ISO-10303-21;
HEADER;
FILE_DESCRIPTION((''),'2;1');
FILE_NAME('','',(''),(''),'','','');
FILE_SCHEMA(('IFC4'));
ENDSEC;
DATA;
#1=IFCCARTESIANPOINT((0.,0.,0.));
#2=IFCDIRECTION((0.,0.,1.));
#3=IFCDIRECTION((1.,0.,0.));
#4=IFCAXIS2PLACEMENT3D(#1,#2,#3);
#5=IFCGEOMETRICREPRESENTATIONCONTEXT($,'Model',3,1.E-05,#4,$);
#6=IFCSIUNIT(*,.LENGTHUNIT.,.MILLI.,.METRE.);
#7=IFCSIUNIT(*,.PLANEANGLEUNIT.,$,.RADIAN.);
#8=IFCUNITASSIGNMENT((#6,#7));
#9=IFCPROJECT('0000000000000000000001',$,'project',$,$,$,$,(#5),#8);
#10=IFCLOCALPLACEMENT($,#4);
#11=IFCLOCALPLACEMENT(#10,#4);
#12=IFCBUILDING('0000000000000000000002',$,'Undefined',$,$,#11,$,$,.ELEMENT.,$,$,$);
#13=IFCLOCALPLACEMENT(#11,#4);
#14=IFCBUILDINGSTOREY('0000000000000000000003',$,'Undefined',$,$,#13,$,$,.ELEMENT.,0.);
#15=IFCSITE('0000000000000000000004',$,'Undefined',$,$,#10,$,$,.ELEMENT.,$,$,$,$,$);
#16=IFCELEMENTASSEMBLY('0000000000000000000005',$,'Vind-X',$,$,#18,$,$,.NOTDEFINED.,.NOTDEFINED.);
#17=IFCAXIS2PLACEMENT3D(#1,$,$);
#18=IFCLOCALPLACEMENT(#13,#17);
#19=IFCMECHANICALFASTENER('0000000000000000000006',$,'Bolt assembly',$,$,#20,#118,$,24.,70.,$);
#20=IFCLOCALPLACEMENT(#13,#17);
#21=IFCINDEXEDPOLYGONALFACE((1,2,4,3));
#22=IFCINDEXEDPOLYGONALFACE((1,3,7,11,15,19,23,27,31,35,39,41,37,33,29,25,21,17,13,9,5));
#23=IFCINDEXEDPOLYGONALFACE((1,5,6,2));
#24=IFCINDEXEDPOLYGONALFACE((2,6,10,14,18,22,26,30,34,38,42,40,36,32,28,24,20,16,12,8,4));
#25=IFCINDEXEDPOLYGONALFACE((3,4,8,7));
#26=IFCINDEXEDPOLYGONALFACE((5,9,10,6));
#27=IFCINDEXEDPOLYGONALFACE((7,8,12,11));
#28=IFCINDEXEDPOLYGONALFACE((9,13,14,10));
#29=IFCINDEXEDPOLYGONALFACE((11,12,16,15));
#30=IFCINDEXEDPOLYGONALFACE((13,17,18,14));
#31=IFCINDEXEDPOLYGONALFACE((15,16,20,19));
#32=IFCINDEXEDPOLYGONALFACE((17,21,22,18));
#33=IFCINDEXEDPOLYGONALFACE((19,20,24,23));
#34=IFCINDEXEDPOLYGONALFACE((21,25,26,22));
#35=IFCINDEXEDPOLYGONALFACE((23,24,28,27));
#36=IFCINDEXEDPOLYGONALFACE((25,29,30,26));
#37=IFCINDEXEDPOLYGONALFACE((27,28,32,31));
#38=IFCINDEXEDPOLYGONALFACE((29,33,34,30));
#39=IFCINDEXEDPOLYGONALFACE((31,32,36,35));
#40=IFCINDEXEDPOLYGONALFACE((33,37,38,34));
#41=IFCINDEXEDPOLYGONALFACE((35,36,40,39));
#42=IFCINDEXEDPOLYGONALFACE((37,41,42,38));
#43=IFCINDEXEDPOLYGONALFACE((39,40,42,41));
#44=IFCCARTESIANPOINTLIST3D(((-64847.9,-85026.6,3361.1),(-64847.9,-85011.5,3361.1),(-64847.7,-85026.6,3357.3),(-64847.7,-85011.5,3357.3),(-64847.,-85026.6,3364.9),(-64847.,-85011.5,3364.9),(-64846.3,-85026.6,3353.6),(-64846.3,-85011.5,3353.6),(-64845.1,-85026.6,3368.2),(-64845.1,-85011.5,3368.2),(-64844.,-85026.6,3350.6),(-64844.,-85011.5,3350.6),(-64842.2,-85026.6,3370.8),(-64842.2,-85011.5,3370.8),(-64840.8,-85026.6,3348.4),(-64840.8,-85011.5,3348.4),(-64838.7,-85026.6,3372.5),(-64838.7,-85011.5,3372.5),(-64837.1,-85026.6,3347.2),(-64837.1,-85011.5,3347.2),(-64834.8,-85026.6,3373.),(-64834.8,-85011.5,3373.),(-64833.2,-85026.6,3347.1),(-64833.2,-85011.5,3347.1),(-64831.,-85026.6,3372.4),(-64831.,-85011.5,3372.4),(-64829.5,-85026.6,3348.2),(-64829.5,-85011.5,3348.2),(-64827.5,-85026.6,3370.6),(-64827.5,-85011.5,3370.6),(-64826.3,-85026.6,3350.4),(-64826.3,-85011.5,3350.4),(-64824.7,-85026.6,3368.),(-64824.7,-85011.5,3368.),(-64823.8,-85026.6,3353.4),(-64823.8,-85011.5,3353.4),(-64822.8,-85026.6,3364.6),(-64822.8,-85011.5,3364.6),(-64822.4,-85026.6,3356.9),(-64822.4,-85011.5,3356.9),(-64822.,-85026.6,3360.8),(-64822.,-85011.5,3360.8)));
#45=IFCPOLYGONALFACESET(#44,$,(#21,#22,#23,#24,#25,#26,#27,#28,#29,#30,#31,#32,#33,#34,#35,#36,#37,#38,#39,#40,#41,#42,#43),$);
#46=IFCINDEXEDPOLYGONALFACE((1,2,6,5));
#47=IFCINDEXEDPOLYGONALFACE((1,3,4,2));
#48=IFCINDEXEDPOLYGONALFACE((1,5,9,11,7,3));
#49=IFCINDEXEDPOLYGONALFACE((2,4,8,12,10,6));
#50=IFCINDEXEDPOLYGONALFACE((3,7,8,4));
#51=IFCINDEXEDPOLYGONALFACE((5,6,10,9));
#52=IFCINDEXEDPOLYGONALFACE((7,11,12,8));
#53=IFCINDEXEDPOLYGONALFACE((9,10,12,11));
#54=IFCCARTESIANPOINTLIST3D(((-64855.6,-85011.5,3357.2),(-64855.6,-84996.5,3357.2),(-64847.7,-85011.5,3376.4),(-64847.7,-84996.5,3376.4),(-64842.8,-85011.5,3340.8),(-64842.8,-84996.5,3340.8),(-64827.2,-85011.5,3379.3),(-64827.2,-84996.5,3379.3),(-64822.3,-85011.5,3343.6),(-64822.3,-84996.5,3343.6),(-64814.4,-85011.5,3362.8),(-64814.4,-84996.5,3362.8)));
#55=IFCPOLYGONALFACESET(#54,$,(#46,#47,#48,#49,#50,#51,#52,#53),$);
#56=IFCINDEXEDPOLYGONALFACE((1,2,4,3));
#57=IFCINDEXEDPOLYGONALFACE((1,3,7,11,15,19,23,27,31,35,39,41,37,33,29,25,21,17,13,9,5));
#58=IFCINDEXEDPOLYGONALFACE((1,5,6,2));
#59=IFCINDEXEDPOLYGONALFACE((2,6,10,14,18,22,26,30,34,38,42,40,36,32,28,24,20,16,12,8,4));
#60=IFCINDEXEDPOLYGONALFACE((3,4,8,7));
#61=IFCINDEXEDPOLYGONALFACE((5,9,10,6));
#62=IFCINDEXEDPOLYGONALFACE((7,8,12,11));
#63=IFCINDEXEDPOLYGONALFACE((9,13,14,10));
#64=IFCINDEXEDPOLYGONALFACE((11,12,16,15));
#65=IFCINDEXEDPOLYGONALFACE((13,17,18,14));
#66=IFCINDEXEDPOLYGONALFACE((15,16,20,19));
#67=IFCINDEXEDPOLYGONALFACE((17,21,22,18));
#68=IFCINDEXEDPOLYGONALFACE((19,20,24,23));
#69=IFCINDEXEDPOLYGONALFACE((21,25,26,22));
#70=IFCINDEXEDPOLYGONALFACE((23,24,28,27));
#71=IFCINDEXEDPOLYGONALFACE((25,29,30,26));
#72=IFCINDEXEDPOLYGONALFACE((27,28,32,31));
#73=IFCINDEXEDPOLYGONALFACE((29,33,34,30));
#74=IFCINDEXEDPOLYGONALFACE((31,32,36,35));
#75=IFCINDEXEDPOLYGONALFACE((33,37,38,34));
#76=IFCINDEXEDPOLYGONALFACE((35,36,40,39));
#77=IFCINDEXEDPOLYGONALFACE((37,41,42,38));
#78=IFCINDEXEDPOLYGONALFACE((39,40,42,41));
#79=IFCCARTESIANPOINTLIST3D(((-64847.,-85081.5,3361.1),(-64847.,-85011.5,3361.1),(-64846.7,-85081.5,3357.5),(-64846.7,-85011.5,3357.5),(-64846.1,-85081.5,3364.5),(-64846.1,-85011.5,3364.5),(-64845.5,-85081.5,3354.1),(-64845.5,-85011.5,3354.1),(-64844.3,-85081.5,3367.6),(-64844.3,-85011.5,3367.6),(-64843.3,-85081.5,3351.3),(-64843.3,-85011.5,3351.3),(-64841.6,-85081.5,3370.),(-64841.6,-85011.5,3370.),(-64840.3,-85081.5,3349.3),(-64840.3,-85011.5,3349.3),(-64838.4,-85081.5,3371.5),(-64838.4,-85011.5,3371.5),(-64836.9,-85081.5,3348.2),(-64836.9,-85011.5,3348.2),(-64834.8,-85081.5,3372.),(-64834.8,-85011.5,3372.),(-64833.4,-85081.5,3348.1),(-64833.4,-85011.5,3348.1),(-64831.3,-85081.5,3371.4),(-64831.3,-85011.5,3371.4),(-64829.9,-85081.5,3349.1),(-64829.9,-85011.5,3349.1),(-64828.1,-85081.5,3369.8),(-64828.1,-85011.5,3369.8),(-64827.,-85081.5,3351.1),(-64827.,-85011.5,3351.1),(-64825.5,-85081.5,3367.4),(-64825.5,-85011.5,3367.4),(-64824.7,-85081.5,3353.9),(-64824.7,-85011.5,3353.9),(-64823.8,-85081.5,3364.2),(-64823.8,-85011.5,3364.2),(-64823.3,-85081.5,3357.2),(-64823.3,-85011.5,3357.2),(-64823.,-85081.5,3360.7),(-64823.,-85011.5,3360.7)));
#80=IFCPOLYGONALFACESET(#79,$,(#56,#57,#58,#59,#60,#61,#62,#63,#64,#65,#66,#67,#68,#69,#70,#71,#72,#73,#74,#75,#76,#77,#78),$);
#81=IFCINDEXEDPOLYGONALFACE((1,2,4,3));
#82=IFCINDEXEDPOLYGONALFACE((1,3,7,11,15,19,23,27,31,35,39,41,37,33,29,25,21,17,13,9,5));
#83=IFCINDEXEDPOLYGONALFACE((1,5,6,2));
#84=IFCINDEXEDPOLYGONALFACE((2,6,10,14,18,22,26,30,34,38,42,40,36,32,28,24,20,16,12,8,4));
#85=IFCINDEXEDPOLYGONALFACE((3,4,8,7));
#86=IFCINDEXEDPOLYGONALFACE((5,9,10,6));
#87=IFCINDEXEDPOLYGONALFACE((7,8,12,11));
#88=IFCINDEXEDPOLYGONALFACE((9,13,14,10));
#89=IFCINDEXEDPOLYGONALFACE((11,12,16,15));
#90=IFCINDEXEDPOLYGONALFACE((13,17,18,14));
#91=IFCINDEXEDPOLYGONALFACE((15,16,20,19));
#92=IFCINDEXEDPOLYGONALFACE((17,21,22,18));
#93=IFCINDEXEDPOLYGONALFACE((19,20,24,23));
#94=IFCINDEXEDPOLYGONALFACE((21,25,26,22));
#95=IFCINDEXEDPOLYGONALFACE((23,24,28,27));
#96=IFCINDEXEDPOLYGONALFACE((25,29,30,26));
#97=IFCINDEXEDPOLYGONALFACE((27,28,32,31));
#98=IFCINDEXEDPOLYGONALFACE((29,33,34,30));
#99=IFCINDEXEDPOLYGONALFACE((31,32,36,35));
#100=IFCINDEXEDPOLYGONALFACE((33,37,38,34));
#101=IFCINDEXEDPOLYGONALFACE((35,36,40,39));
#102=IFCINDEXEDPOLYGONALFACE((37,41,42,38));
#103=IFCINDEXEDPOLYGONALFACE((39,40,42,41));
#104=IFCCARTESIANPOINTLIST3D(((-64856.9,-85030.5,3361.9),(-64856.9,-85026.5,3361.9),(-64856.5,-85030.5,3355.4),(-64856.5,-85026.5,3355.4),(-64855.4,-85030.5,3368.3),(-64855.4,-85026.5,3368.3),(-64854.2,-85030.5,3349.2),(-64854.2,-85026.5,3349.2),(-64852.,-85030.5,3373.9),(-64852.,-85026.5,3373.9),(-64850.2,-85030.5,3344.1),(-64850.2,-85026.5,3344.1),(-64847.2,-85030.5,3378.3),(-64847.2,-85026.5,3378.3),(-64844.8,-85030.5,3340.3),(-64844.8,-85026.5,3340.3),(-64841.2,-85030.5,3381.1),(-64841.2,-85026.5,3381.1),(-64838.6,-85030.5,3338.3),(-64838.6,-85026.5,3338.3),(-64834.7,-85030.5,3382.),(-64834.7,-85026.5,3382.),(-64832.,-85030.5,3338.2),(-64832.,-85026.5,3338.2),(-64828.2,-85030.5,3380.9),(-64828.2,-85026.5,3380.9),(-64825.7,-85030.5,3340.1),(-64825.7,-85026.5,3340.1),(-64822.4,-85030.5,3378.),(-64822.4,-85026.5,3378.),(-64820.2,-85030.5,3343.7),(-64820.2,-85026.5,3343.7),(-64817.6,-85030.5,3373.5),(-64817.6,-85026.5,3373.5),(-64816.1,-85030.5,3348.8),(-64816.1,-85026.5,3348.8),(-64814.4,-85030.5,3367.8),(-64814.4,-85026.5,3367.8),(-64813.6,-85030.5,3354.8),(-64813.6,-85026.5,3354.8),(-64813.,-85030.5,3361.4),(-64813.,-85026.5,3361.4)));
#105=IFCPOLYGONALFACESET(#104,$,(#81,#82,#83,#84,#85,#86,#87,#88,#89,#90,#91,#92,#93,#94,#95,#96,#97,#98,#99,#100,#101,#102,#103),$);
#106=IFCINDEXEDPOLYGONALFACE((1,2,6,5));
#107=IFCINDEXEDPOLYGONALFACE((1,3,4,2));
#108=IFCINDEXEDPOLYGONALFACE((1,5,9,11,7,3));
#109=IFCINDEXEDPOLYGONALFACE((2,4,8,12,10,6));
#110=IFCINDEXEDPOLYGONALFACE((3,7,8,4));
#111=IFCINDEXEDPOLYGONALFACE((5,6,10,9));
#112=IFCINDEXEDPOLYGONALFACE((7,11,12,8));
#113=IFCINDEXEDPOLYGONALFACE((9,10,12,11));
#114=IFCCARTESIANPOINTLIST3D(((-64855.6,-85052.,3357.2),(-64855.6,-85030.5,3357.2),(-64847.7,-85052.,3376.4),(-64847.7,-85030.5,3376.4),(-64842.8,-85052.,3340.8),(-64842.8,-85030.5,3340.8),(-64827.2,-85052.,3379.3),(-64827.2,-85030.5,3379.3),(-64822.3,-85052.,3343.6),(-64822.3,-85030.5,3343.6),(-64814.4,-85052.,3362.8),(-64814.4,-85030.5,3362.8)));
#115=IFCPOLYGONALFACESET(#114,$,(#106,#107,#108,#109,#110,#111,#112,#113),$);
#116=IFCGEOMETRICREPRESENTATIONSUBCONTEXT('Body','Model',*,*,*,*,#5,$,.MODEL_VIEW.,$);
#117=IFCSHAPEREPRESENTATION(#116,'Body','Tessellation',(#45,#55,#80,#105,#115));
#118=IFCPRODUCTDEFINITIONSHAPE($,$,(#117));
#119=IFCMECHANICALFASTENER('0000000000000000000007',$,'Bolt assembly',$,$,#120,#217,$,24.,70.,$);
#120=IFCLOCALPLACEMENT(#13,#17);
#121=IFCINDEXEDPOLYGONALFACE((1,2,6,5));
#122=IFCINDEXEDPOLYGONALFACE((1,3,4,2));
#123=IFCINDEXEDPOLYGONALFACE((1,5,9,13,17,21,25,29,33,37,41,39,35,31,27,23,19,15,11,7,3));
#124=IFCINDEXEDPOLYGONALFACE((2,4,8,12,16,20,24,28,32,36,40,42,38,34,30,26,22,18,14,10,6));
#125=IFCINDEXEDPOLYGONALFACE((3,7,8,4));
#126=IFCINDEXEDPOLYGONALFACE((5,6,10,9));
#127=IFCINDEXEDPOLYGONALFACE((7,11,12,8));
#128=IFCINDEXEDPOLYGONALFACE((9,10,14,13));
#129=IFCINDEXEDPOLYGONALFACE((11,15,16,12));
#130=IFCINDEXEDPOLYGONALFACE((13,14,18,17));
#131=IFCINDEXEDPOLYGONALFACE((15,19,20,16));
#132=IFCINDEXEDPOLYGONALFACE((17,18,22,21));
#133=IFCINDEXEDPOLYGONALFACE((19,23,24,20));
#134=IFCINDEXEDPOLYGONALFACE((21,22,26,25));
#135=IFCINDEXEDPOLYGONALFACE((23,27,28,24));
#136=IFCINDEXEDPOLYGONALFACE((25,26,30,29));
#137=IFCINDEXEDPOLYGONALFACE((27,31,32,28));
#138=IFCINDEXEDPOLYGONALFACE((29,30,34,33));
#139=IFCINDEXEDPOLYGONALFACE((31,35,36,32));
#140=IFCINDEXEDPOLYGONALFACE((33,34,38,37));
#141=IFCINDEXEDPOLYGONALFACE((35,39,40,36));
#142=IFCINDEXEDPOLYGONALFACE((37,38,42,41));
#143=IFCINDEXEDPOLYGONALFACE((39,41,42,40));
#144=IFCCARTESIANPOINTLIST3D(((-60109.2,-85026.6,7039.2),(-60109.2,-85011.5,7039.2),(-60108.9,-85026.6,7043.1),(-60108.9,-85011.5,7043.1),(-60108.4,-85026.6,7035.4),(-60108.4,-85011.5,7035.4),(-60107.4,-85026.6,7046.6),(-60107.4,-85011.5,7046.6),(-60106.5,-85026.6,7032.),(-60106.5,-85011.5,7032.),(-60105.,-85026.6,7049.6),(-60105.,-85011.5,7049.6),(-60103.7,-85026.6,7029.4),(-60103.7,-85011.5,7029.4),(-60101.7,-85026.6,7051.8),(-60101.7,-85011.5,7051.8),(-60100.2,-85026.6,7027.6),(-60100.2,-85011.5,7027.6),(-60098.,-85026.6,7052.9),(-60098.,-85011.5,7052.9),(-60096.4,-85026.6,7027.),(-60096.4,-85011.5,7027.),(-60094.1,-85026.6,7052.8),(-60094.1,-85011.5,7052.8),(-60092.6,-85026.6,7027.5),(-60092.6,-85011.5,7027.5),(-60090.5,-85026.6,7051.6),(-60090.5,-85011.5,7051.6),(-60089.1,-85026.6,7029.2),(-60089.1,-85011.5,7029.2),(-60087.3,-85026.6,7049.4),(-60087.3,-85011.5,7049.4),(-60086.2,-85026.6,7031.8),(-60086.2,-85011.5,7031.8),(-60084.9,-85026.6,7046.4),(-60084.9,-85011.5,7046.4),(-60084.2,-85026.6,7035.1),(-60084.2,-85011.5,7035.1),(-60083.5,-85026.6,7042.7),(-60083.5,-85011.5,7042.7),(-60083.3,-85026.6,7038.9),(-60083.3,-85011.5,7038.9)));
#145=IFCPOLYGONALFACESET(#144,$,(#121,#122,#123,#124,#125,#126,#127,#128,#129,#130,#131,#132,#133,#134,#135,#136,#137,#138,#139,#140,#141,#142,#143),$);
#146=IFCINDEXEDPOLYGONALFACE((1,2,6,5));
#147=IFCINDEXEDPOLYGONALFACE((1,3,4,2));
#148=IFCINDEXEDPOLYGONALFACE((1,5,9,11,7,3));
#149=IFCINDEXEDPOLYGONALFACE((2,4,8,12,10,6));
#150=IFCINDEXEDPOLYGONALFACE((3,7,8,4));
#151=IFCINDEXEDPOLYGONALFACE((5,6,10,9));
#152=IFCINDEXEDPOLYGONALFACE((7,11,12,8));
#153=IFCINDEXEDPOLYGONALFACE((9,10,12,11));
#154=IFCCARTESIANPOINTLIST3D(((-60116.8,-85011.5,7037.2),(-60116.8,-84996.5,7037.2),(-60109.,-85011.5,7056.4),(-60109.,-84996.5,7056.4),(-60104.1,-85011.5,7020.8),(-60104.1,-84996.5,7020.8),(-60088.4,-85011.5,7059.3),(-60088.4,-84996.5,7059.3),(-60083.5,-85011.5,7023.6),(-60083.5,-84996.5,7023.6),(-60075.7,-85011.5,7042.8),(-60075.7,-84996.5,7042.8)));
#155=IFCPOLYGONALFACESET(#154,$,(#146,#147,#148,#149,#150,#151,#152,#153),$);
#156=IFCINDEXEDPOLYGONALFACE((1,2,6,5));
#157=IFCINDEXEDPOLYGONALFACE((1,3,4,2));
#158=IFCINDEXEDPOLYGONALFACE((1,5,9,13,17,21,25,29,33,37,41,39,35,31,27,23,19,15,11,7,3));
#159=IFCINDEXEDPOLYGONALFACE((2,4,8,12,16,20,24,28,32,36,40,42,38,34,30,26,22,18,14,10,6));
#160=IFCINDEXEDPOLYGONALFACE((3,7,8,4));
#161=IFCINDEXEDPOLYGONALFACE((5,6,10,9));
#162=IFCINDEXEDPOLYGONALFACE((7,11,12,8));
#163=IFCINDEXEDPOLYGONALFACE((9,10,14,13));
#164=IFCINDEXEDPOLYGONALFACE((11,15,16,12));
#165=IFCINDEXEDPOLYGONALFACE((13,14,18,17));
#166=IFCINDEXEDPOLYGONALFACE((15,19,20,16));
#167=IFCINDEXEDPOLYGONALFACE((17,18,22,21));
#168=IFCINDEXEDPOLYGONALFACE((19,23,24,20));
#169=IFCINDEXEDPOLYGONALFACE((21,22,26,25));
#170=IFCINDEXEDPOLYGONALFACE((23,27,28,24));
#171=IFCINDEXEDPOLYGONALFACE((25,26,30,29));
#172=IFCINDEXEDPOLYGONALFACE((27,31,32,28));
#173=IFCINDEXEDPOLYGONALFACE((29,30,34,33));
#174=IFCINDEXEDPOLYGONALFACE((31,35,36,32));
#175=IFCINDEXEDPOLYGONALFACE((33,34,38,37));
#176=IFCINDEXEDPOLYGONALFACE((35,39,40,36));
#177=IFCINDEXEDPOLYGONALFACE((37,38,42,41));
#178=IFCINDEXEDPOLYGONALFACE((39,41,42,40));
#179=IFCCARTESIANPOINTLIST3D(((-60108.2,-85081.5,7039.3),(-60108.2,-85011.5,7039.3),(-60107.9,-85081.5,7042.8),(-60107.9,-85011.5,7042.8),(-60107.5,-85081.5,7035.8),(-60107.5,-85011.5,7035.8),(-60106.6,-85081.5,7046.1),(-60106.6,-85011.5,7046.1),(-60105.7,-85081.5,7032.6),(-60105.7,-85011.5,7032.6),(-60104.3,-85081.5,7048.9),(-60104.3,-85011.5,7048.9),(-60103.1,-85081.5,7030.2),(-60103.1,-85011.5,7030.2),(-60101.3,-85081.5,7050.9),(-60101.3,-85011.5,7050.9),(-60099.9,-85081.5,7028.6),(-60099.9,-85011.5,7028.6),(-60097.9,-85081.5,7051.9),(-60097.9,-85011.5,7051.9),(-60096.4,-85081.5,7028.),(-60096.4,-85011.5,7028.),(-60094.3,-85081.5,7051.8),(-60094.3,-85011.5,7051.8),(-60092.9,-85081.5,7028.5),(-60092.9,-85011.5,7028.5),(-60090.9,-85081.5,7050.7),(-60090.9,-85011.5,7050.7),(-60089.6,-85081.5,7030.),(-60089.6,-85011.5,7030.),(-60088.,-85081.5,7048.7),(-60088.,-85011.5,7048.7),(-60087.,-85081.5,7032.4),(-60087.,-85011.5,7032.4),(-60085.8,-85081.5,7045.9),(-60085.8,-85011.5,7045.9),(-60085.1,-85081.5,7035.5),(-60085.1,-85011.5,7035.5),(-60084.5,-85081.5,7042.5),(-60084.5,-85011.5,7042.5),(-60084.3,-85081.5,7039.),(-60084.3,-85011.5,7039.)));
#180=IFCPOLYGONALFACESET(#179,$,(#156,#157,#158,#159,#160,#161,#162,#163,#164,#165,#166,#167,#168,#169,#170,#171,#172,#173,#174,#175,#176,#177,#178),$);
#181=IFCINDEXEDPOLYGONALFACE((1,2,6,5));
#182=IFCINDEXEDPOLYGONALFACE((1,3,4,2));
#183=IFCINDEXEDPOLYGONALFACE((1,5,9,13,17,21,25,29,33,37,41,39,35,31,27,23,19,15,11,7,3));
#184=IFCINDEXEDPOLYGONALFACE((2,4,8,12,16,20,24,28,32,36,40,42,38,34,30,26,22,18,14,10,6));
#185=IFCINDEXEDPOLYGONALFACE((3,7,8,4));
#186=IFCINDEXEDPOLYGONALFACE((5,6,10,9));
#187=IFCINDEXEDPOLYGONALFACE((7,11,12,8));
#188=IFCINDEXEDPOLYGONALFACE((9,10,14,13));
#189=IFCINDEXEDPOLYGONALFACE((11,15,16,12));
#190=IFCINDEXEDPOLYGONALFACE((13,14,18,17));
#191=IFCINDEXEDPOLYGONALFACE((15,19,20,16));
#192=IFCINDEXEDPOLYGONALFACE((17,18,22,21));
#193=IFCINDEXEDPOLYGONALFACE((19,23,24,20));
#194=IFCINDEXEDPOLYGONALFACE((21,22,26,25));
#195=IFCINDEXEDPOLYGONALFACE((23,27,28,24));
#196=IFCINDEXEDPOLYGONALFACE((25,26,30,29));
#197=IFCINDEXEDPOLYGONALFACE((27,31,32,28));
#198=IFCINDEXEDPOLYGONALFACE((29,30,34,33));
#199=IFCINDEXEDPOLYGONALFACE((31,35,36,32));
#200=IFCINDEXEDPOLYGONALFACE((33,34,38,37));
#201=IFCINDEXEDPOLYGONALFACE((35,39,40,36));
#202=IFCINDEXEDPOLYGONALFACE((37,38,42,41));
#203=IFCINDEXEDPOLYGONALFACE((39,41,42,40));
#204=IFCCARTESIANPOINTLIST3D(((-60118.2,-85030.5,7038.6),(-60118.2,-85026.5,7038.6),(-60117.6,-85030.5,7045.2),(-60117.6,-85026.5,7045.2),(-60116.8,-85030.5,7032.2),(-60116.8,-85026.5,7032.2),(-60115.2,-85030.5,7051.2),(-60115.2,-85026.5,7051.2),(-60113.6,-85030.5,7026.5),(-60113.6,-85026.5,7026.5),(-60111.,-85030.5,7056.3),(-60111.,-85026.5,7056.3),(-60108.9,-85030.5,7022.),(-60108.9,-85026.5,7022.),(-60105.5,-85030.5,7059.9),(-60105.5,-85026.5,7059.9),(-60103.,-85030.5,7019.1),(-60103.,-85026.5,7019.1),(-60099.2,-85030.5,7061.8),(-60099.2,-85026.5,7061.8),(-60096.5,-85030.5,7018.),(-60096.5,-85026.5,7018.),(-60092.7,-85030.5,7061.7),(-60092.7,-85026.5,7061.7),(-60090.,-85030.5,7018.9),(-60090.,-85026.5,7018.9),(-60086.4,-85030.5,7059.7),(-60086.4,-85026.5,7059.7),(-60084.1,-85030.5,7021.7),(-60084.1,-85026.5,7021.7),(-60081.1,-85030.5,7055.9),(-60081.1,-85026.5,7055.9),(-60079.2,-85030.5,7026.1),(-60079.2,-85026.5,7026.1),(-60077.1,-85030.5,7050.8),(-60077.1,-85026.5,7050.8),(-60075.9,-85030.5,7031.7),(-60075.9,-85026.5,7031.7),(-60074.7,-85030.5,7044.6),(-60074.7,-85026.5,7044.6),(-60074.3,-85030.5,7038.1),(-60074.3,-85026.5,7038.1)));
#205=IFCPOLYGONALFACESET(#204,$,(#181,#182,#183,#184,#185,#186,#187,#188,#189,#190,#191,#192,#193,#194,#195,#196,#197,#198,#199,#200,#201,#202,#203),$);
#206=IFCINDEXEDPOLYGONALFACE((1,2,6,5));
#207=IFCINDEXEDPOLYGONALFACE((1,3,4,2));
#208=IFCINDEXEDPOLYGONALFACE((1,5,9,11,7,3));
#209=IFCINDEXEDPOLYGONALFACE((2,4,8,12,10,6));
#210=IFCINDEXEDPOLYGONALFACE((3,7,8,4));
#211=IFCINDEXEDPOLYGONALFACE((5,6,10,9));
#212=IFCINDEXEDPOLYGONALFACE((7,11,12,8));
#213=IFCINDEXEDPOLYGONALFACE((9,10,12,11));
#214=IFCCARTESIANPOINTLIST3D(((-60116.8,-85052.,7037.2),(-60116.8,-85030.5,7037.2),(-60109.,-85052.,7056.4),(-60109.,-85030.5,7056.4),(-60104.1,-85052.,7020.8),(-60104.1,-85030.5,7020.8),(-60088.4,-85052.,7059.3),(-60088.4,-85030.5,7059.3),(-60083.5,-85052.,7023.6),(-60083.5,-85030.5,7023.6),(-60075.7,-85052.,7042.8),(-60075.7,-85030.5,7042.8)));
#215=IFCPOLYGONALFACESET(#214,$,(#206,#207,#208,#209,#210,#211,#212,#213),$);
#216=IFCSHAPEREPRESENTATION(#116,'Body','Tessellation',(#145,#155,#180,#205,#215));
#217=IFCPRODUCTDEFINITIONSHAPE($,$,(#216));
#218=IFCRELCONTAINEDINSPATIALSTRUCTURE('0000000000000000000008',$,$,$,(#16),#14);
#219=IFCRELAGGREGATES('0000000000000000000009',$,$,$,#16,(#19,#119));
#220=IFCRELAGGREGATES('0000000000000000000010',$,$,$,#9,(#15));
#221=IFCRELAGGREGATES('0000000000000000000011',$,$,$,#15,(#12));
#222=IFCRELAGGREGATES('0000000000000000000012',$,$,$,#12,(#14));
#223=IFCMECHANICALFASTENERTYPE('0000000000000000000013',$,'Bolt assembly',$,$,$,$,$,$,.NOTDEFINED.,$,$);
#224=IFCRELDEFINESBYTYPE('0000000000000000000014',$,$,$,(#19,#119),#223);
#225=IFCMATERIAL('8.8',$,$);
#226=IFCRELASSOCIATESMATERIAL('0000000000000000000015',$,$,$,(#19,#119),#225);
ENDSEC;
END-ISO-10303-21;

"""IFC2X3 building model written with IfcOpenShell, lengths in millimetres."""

from ifc_helpers import new_model, si_unit, frame, origin_with_axes, origin_2d_with_axis, place, context, subcontext, project, spatial, polyline, circle, outline, extrude, source, transform, mapped, material, type_object, element, aggregate, save


model = new_model("IFC2X3")

# Units and contexts
model_context = context("Model", 3, precision=1e-05, world=origin_with_axes())
body_context = subcontext(model_context, "Body", "Model", "MODEL_VIEW")
ifc_project = project(units=[si_unit("LENGTHUNIT", "METRE", prefix="MILLI"), si_unit("PLANEANGLEUNIT", "RADIAN")], contexts=[model_context])

# Site, building, storey
site_placement = place(None, origin_with_axes())
site = spatial("IfcSite", under=ifc_project, at=site_placement, Name="Undefined", CompositionType="ELEMENT")
building_placement = place(site_placement, origin_with_axes())
building = spatial("IfcBuilding", under=site, at=building_placement, Name="Undefined", CompositionType="ELEMENT")
storey_placement = place(building_placement, origin_with_axes())
storey = spatial("IfcBuildingStorey", under=building, at=storey_placement, Name="Undefined", CompositionType="ELEMENT", Elevation=0.0)

# Element assembly
assembly_1_placement = place(storey_placement, origin_with_axes())
assembly_1 = element("IfcElementAssembly", 1, at=assembly_1_placement, inside=storey, Name="Vind-X", AssemblyPlace="NOTDEFINED", PredefinedType="NOTDEFINED")

# Mechanical fasteners
ifc_material_1 = material(Name="8.8")
mechanical_fastener_type = type_object("IfcMechanicalFastenerType", Name="Bolt assembly")
shared_shape_1 = source(origin_with_axes(), body_context, "Body", "SweptSolid", [
    extrude(circle(Radius=13.0, at=origin_2d_with_axis()), frame((0.0, 0.0, 0.0), z_axis=(0.0, 1.0, 0.0), x_axis=(1.0, 0.0, 0.0)), (0.0, 0.0, 1.0), 15.1),
    extrude(outline(polyline([(18.0, -10.4), (18.0, 10.4), (0.0, 20.8), (-18.0, 10.4), (-18.0, -10.4), (0.0, -20.8), (18.0, -10.4)])), frame((0.0, -15.0, 0.0), z_axis=(0.0, 1.0, 0.0), x_axis=(1.0, 0.0, 0.0)), (0.0, 0.0, 1.0), 15.0),
    extrude(circle(Radius=12.0, at=origin_2d_with_axis()), frame((0.0, 0.0, 0.0), z_axis=(0.0, 1.0, 0.0), x_axis=(1.0, 0.0, 0.0)), (0.0, 0.0, 1.0), 70.0),
    extrude(circle(Radius=22.0, at=origin_2d_with_axis()), frame((0.0, 15.0, 0.0), z_axis=(0.0, 1.0, 0.0), x_axis=(1.0, 0.0, 0.0)), (0.0, 0.0, 1.0), 4.0),
    extrude(outline(polyline([(18.0, -10.4), (18.0, 10.4), (0.0, 20.8), (-18.0, 10.4), (-18.0, -10.4), (0.0, -20.8), (18.0, -10.4)])), frame((0.0, 19.0, 0.0), z_axis=(0.0, 1.0, 0.0), x_axis=(1.0, 0.0, 0.0)), (0.0, 0.0, 1.0), 21.5),
])
mechanical_fastener_1_placement = place(assembly_1_placement, frame((-64835.0, -85011.5, 3360.0), z_axis=(0.613349, 0.0, -0.789812), x_axis=(0.789812, 0.0, 0.613349)))
mechanical_fastener_1 = element("IfcMechanicalFastener", 2, at=mechanical_fastener_1_placement, type_object=mechanical_fastener_type, material=ifc_material_1, Name="Bolt assembly", NominalDiameter=24.0, NominalLength=70.0, context=body_context, shape_type="MappedRepresentation", body=[
    mapped(shared_shape_1, transform((0.0, 0.0, 0.0))),
])
mechanical_fastener_2_placement = place(assembly_1_placement, frame((-60096.2, -85011.5, 7040.0), z_axis=(-0.613349, 0.0, 0.789812), x_axis=(-0.789812, 0.0, -0.613349)))
mechanical_fastener_2 = element("IfcMechanicalFastener", 3, at=mechanical_fastener_2_placement, type_object=mechanical_fastener_type, material=ifc_material_1, Name="Bolt assembly", NominalDiameter=24.0, NominalLength=70.0, context=body_context, shape_type="MappedRepresentation", body=[
    mapped(shared_shape_1, transform((0.0, 0.0, 0.0))),
])
aggregate(assembly_1, [mechanical_fastener_1, mechanical_fastener_2])

save(model, "model.ifc")
